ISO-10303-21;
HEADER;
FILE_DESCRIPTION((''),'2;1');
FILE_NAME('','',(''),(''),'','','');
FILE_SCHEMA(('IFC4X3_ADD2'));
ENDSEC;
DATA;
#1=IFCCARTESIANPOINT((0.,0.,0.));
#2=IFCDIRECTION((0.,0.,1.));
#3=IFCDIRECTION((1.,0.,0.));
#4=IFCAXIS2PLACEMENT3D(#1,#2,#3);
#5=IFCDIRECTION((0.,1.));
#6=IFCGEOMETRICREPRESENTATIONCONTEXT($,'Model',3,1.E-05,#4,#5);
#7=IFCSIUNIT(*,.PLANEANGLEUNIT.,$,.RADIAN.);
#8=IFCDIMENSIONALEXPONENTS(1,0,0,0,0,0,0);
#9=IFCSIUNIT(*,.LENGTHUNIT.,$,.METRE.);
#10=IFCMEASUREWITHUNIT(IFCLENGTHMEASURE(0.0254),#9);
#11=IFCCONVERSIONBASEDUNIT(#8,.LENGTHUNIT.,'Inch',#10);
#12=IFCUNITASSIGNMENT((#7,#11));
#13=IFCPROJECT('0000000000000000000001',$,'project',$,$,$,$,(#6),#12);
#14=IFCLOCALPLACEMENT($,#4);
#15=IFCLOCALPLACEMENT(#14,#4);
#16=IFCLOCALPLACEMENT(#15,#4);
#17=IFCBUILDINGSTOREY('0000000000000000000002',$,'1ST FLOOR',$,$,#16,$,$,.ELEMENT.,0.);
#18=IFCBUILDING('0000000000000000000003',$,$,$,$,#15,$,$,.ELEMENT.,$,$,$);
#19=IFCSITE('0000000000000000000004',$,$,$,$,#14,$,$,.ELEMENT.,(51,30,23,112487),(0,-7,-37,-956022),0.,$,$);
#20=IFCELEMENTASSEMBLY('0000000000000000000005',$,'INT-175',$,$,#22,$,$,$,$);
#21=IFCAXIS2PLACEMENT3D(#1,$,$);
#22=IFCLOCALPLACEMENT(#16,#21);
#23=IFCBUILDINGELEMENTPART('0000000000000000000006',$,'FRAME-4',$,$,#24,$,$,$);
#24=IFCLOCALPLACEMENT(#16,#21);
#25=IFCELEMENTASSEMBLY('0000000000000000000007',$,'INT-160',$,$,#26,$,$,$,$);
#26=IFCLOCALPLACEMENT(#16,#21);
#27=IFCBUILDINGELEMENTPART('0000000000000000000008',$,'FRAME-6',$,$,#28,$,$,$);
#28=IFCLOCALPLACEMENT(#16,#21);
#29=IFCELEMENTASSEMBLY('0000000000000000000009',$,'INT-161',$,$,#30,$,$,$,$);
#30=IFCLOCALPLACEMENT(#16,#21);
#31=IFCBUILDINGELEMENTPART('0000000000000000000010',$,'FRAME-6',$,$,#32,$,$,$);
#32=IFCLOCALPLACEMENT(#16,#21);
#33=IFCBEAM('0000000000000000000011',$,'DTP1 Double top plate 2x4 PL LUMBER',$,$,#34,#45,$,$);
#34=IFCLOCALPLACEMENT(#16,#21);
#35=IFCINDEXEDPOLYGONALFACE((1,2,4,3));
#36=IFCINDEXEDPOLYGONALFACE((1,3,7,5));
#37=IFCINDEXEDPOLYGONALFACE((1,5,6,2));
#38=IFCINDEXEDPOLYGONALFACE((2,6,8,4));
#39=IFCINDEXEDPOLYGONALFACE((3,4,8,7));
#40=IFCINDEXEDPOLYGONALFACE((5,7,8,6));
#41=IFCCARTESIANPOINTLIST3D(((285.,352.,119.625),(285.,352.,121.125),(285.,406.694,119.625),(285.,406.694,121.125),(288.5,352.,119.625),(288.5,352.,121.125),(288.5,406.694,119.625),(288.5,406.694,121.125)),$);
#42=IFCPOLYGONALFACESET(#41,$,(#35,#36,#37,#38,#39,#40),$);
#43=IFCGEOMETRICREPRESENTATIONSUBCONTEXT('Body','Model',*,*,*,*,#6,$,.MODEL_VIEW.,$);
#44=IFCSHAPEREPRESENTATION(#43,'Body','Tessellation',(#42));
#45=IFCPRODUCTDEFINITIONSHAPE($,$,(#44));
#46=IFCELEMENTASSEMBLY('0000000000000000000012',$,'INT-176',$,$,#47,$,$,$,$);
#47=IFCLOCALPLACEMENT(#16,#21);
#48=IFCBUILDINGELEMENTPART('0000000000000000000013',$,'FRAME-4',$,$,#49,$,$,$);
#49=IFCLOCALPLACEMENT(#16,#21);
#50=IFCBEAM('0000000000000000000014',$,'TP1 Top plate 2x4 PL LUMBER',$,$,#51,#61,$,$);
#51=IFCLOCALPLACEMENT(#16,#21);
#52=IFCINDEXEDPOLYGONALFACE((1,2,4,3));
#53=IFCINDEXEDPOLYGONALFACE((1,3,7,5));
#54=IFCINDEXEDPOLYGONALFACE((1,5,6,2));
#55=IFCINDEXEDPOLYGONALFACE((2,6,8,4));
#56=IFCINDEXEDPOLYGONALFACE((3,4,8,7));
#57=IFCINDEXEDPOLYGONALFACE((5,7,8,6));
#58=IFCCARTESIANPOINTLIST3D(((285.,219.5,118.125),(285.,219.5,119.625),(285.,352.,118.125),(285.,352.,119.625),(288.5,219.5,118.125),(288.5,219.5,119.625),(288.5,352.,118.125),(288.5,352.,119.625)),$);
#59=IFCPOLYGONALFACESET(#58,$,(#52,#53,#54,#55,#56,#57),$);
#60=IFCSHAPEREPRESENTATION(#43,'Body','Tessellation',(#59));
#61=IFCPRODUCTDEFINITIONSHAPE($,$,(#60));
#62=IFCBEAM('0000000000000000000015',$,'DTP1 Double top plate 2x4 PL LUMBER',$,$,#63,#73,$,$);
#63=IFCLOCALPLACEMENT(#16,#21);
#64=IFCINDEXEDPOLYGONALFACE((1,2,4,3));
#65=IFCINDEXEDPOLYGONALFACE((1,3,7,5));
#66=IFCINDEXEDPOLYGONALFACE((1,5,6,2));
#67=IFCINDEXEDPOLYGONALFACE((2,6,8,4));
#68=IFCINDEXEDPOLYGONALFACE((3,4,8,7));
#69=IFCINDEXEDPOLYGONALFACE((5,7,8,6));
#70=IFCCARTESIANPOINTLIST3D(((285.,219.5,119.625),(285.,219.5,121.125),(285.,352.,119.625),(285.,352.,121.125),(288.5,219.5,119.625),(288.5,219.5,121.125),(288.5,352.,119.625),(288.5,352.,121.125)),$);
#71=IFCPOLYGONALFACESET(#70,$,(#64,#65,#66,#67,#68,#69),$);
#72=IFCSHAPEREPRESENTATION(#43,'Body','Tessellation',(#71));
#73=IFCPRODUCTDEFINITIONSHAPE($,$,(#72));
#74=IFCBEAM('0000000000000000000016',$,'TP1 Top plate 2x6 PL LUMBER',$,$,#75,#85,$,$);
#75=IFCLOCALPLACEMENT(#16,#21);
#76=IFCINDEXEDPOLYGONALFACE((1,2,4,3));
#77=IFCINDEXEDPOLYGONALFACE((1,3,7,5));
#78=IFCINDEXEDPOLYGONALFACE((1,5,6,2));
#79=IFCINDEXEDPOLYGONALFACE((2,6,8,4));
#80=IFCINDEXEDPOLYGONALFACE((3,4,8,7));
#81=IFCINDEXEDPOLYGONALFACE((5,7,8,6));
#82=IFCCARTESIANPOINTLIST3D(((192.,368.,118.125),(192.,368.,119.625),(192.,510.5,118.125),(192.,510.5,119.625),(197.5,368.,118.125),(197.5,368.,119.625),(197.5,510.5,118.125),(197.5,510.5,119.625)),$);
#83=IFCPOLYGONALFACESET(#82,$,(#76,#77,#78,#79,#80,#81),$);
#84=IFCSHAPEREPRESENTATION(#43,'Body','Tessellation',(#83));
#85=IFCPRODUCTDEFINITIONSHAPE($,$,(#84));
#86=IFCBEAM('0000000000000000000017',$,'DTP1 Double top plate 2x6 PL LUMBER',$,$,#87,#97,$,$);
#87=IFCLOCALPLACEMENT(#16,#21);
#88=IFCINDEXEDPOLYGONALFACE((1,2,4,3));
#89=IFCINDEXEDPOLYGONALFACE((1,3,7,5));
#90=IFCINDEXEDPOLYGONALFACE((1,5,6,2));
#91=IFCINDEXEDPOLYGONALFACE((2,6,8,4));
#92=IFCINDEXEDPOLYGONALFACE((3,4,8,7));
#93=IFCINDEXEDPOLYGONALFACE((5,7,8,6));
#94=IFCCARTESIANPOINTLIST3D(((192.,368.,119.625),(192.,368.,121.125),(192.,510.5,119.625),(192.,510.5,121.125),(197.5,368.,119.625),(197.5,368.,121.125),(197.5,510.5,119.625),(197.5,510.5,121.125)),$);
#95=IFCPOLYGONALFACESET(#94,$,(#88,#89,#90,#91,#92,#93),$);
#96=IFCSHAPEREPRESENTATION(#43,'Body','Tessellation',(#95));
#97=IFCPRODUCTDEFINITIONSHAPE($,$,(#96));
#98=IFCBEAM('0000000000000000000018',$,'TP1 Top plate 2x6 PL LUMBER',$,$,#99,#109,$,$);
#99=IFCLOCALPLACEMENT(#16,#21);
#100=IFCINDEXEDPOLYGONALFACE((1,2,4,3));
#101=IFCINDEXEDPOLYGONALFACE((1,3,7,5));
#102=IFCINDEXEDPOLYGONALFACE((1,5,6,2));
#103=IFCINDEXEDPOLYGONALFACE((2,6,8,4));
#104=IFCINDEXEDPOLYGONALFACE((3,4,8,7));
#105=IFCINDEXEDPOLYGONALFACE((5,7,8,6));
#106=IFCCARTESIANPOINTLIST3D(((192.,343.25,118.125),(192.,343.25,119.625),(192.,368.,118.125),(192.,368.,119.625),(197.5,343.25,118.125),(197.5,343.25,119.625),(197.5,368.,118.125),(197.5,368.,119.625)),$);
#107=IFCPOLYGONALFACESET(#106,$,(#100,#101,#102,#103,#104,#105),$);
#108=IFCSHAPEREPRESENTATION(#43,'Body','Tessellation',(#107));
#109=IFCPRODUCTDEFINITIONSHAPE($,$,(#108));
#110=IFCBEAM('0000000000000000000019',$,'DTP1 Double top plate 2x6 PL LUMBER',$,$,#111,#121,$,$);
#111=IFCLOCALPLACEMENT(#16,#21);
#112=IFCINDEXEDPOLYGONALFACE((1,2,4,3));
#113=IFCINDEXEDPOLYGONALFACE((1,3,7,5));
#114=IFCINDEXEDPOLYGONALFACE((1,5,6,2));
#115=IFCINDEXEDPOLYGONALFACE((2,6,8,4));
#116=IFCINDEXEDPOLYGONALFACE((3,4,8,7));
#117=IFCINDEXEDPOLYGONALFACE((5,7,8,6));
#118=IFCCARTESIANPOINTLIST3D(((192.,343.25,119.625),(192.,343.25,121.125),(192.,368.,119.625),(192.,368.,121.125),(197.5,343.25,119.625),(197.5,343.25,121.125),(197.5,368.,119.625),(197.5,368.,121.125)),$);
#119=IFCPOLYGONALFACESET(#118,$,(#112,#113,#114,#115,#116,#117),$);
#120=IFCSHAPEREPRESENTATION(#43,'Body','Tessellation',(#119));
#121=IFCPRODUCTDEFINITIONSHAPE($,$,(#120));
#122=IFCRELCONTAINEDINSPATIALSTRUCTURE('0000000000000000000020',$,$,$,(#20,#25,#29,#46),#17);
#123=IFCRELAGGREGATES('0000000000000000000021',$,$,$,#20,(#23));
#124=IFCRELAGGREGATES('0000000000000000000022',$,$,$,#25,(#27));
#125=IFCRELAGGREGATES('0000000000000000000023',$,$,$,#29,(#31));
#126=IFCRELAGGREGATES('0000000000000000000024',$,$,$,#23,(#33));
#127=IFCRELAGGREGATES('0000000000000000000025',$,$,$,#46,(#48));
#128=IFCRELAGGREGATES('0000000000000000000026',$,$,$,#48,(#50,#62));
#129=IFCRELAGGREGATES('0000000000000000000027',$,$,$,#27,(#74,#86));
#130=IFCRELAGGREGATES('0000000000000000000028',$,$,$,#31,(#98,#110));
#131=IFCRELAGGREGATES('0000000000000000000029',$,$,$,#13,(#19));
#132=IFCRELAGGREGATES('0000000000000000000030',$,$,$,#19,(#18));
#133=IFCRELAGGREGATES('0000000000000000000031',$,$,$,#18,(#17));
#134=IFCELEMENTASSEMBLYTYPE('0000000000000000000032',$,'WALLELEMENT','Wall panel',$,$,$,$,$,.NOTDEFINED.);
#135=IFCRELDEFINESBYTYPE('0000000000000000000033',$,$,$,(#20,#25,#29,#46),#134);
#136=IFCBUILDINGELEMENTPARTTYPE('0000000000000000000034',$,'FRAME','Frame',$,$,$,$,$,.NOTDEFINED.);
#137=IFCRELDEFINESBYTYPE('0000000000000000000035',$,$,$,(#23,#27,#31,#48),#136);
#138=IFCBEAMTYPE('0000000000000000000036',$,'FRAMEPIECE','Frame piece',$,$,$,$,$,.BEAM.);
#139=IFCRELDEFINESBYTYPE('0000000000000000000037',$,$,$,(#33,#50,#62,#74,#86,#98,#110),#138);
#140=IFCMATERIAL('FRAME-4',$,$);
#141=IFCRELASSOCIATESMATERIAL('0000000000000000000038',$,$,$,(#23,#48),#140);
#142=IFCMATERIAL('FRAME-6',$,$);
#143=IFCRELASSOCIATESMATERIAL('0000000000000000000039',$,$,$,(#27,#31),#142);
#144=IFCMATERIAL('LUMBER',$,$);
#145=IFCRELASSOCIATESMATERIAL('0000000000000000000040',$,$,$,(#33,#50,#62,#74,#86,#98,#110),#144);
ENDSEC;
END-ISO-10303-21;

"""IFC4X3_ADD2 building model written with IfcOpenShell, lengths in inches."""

from ifc_helpers import new_model, entity, si_unit, converted_unit, direction, frame, origin_with_axes, origin_2d_with_axis, place, context, subcontext, project, spatial, rectangle, extrude, material, type_object, element, aggregate, save


model = new_model("IFC4X3_ADD2")

# Units and contexts
model_context = context("Model", 3, precision=1e-05, world=origin_with_axes(), true_north=direction((0.0, 1.0)))
body_context = subcontext(model_context, "Body", "Model", "MODEL_VIEW")
ifc_project = project(units=[si_unit("PLANEANGLEUNIT", "RADIAN"), converted_unit("LENGTHUNIT", "Inch", entity("IfcLengthMeasure", 0.0254), si_unit("LENGTHUNIT", "METRE"), dimensions=[1, 0, 0, 0, 0, 0, 0])], contexts=[model_context])

# Site, building, storey
site_placement = place(None, origin_with_axes())
site = spatial("IfcSite", under=ifc_project, at=site_placement, CompositionType="ELEMENT", RefLatitude=(51, 30, 23, 112487), RefLongitude=(0, -7, -37, -956022), RefElevation=0.0)
building_placement = place(site_placement, origin_with_axes())
building = spatial("IfcBuilding", under=site, at=building_placement, CompositionType="ELEMENT")
storey_placement = place(building_placement, origin_with_axes())
storey = spatial("IfcBuildingStorey", under=building, at=storey_placement, Name="1ST FLOOR", CompositionType="ELEMENT", Elevation=0.0)

# Shared definitions
element_assembly_type = type_object("IfcElementAssemblyType", Name="WALLELEMENT", Description="Wall panel", PredefinedType="NOTDEFINED")
ifc_material_1 = material(Name="FRAME-4")
building_element_part_type = type_object("IfcBuildingElementPartType", Name="FRAME", Description="Frame", PredefinedType="NOTDEFINED")
ifc_material_2 = material(Name="LUMBER")

# Element assemblies, building element parts
assembly_1_placement = place(storey_placement, origin_with_axes())
assembly_1 = element("IfcElementAssembly", 1, at=assembly_1_placement, inside=storey, type_object=element_assembly_type, Name="INT-175")
building_element_part_1_placement = place(storey_placement, origin_with_axes())
building_element_part_1 = element("IfcBuildingElementPart", 2, at=building_element_part_1_placement, type_object=building_element_part_type, material=ifc_material_1, Name="FRAME-4")
aggregate(assembly_1, [building_element_part_1])
assembly_2_placement = place(storey_placement, origin_with_axes())
assembly_2 = element("IfcElementAssembly", 3, at=assembly_2_placement, inside=storey, type_object=element_assembly_type, Name="INT-160")
ifc_material_3 = material(Name="FRAME-6")
building_element_part_2_placement = place(storey_placement, origin_with_axes())
building_element_part_2 = element("IfcBuildingElementPart", 4, at=building_element_part_2_placement, type_object=building_element_part_type, material=ifc_material_3, Name="FRAME-6")
aggregate(assembly_2, [building_element_part_2])
assembly_3_placement = place(storey_placement, origin_with_axes())
assembly_3 = element("IfcElementAssembly", 5, at=assembly_3_placement, inside=storey, type_object=element_assembly_type, Name="INT-161")
building_element_part_3_placement = place(storey_placement, origin_with_axes())
building_element_part_3 = element("IfcBuildingElementPart", 6, at=building_element_part_3_placement, type_object=building_element_part_type, material=ifc_material_3, Name="FRAME-6")
aggregate(assembly_3, [building_element_part_3])

# Beam
beam_type = type_object("IfcBeamType", Name="FRAMEPIECE", Description="Frame piece", PredefinedType="BEAM")
beam_1_placement = place(storey_placement, frame((286.75, 406.694, 120.375), z_axis=(0.0, -1.0, 0.0), x_axis=(0.0, 0.0, -1.0)))
beam_1 = element("IfcBeam", 7, at=beam_1_placement, type_object=beam_type, material=ifc_material_2, Name="DTP1 Double top plate 2x4 PL LUMBER", context=body_context, shape_type="SweptSolid", body=[
    extrude(rectangle(XDim=1.5, YDim=3.5, at=origin_2d_with_axis()), origin_with_axes(), (0.0, 0.0, 1.0), 54.694),
])
aggregate(building_element_part_1, [beam_1])

# Element assembly, building element part, beams
assembly_4_placement = place(storey_placement, origin_with_axes())
assembly_4 = element("IfcElementAssembly", 8, at=assembly_4_placement, inside=storey, type_object=element_assembly_type, Name="INT-176")
building_element_part_4_placement = place(storey_placement, origin_with_axes())
building_element_part_4 = element("IfcBuildingElementPart", 9, at=building_element_part_4_placement, type_object=building_element_part_type, material=ifc_material_1, Name="FRAME-4")
aggregate(assembly_4, [building_element_part_4])
beam_2_placement = place(storey_placement, frame((286.75, 352.0, 118.875), z_axis=(0.0, -1.0, 0.0), x_axis=(0.0, 0.0, -1.0)))
beam_2 = element("IfcBeam", 10, at=beam_2_placement, type_object=beam_type, material=ifc_material_2, Name="TP1 Top plate 2x4 PL LUMBER", context=body_context, shape_type="SweptSolid", body=[
    extrude(rectangle(XDim=1.5, YDim=3.5, at=origin_2d_with_axis()), origin_with_axes(), (0.0, 0.0, 1.0), 132.5),
])
beam_3_placement = place(storey_placement, frame((286.75, 352.0, 120.375), z_axis=(0.0, -1.0, 0.0), x_axis=(0.0, 0.0, -1.0)))
beam_3 = element("IfcBeam", 11, at=beam_3_placement, type_object=beam_type, material=ifc_material_2, Name="DTP1 Double top plate 2x4 PL LUMBER", context=body_context, shape_type="SweptSolid", body=[
    extrude(rectangle(XDim=1.5, YDim=3.5, at=origin_2d_with_axis()), origin_with_axes(), (0.0, 0.0, 1.0), 132.5),
])
aggregate(building_element_part_4, [beam_2, beam_3])

# Beams
beam_4_placement = place(storey_placement, frame((194.75, 368.0, 118.875), z_axis=(0.0, 1.0, 0.0), x_axis=(0.0, 0.0, -1.0)))
beam_4 = element("IfcBeam", 12, at=beam_4_placement, type_object=beam_type, material=ifc_material_2, Name="TP1 Top plate 2x6 PL LUMBER", context=body_context, shape_type="SweptSolid", body=[
    extrude(rectangle(XDim=1.5, YDim=5.5, at=origin_2d_with_axis()), origin_with_axes(), (0.0, 0.0, 1.0), 142.5),
])
beam_5_placement = place(storey_placement, frame((194.75, 368.0, 120.375), z_axis=(0.0, 1.0, 0.0), x_axis=(0.0, 0.0, -1.0)))
beam_5 = element("IfcBeam", 13, at=beam_5_placement, type_object=beam_type, material=ifc_material_2, Name="DTP1 Double top plate 2x6 PL LUMBER", context=body_context, shape_type="SweptSolid", body=[
    extrude(rectangle(XDim=1.5, YDim=5.5, at=origin_2d_with_axis()), origin_with_axes(), (0.0, 0.0, 1.0), 142.5),
])
aggregate(building_element_part_2, [beam_4, beam_5])
beam_6_placement = place(storey_placement, frame((194.75, 343.25, 118.875), z_axis=(0.0, 1.0, 0.0), x_axis=(0.0, 0.0, -1.0)))
beam_6 = element("IfcBeam", 14, at=beam_6_placement, type_object=beam_type, material=ifc_material_2, Name="TP1 Top plate 2x6 PL LUMBER", context=body_context, shape_type="SweptSolid", body=[
    extrude(rectangle(XDim=1.5, YDim=5.5, at=origin_2d_with_axis()), origin_with_axes(), (0.0, 0.0, 1.0), 24.75),
])
beam_7_placement = place(storey_placement, frame((194.75, 368.0, 120.375), z_axis=(0.0, -1.0, 0.0), x_axis=(0.0, 0.0, 1.0)))
beam_7 = element("IfcBeam", 15, at=beam_7_placement, type_object=beam_type, material=ifc_material_2, Name="DTP1 Double top plate 2x6 PL LUMBER", context=body_context, shape_type="SweptSolid", body=[
    extrude(rectangle(XDim=1.5, YDim=5.5, at=origin_2d_with_axis()), origin_with_axes(), (0.0, 0.0, 1.0), 24.75),
])
aggregate(building_element_part_3, [beam_6, beam_7])

save(model, "model.ifc")
